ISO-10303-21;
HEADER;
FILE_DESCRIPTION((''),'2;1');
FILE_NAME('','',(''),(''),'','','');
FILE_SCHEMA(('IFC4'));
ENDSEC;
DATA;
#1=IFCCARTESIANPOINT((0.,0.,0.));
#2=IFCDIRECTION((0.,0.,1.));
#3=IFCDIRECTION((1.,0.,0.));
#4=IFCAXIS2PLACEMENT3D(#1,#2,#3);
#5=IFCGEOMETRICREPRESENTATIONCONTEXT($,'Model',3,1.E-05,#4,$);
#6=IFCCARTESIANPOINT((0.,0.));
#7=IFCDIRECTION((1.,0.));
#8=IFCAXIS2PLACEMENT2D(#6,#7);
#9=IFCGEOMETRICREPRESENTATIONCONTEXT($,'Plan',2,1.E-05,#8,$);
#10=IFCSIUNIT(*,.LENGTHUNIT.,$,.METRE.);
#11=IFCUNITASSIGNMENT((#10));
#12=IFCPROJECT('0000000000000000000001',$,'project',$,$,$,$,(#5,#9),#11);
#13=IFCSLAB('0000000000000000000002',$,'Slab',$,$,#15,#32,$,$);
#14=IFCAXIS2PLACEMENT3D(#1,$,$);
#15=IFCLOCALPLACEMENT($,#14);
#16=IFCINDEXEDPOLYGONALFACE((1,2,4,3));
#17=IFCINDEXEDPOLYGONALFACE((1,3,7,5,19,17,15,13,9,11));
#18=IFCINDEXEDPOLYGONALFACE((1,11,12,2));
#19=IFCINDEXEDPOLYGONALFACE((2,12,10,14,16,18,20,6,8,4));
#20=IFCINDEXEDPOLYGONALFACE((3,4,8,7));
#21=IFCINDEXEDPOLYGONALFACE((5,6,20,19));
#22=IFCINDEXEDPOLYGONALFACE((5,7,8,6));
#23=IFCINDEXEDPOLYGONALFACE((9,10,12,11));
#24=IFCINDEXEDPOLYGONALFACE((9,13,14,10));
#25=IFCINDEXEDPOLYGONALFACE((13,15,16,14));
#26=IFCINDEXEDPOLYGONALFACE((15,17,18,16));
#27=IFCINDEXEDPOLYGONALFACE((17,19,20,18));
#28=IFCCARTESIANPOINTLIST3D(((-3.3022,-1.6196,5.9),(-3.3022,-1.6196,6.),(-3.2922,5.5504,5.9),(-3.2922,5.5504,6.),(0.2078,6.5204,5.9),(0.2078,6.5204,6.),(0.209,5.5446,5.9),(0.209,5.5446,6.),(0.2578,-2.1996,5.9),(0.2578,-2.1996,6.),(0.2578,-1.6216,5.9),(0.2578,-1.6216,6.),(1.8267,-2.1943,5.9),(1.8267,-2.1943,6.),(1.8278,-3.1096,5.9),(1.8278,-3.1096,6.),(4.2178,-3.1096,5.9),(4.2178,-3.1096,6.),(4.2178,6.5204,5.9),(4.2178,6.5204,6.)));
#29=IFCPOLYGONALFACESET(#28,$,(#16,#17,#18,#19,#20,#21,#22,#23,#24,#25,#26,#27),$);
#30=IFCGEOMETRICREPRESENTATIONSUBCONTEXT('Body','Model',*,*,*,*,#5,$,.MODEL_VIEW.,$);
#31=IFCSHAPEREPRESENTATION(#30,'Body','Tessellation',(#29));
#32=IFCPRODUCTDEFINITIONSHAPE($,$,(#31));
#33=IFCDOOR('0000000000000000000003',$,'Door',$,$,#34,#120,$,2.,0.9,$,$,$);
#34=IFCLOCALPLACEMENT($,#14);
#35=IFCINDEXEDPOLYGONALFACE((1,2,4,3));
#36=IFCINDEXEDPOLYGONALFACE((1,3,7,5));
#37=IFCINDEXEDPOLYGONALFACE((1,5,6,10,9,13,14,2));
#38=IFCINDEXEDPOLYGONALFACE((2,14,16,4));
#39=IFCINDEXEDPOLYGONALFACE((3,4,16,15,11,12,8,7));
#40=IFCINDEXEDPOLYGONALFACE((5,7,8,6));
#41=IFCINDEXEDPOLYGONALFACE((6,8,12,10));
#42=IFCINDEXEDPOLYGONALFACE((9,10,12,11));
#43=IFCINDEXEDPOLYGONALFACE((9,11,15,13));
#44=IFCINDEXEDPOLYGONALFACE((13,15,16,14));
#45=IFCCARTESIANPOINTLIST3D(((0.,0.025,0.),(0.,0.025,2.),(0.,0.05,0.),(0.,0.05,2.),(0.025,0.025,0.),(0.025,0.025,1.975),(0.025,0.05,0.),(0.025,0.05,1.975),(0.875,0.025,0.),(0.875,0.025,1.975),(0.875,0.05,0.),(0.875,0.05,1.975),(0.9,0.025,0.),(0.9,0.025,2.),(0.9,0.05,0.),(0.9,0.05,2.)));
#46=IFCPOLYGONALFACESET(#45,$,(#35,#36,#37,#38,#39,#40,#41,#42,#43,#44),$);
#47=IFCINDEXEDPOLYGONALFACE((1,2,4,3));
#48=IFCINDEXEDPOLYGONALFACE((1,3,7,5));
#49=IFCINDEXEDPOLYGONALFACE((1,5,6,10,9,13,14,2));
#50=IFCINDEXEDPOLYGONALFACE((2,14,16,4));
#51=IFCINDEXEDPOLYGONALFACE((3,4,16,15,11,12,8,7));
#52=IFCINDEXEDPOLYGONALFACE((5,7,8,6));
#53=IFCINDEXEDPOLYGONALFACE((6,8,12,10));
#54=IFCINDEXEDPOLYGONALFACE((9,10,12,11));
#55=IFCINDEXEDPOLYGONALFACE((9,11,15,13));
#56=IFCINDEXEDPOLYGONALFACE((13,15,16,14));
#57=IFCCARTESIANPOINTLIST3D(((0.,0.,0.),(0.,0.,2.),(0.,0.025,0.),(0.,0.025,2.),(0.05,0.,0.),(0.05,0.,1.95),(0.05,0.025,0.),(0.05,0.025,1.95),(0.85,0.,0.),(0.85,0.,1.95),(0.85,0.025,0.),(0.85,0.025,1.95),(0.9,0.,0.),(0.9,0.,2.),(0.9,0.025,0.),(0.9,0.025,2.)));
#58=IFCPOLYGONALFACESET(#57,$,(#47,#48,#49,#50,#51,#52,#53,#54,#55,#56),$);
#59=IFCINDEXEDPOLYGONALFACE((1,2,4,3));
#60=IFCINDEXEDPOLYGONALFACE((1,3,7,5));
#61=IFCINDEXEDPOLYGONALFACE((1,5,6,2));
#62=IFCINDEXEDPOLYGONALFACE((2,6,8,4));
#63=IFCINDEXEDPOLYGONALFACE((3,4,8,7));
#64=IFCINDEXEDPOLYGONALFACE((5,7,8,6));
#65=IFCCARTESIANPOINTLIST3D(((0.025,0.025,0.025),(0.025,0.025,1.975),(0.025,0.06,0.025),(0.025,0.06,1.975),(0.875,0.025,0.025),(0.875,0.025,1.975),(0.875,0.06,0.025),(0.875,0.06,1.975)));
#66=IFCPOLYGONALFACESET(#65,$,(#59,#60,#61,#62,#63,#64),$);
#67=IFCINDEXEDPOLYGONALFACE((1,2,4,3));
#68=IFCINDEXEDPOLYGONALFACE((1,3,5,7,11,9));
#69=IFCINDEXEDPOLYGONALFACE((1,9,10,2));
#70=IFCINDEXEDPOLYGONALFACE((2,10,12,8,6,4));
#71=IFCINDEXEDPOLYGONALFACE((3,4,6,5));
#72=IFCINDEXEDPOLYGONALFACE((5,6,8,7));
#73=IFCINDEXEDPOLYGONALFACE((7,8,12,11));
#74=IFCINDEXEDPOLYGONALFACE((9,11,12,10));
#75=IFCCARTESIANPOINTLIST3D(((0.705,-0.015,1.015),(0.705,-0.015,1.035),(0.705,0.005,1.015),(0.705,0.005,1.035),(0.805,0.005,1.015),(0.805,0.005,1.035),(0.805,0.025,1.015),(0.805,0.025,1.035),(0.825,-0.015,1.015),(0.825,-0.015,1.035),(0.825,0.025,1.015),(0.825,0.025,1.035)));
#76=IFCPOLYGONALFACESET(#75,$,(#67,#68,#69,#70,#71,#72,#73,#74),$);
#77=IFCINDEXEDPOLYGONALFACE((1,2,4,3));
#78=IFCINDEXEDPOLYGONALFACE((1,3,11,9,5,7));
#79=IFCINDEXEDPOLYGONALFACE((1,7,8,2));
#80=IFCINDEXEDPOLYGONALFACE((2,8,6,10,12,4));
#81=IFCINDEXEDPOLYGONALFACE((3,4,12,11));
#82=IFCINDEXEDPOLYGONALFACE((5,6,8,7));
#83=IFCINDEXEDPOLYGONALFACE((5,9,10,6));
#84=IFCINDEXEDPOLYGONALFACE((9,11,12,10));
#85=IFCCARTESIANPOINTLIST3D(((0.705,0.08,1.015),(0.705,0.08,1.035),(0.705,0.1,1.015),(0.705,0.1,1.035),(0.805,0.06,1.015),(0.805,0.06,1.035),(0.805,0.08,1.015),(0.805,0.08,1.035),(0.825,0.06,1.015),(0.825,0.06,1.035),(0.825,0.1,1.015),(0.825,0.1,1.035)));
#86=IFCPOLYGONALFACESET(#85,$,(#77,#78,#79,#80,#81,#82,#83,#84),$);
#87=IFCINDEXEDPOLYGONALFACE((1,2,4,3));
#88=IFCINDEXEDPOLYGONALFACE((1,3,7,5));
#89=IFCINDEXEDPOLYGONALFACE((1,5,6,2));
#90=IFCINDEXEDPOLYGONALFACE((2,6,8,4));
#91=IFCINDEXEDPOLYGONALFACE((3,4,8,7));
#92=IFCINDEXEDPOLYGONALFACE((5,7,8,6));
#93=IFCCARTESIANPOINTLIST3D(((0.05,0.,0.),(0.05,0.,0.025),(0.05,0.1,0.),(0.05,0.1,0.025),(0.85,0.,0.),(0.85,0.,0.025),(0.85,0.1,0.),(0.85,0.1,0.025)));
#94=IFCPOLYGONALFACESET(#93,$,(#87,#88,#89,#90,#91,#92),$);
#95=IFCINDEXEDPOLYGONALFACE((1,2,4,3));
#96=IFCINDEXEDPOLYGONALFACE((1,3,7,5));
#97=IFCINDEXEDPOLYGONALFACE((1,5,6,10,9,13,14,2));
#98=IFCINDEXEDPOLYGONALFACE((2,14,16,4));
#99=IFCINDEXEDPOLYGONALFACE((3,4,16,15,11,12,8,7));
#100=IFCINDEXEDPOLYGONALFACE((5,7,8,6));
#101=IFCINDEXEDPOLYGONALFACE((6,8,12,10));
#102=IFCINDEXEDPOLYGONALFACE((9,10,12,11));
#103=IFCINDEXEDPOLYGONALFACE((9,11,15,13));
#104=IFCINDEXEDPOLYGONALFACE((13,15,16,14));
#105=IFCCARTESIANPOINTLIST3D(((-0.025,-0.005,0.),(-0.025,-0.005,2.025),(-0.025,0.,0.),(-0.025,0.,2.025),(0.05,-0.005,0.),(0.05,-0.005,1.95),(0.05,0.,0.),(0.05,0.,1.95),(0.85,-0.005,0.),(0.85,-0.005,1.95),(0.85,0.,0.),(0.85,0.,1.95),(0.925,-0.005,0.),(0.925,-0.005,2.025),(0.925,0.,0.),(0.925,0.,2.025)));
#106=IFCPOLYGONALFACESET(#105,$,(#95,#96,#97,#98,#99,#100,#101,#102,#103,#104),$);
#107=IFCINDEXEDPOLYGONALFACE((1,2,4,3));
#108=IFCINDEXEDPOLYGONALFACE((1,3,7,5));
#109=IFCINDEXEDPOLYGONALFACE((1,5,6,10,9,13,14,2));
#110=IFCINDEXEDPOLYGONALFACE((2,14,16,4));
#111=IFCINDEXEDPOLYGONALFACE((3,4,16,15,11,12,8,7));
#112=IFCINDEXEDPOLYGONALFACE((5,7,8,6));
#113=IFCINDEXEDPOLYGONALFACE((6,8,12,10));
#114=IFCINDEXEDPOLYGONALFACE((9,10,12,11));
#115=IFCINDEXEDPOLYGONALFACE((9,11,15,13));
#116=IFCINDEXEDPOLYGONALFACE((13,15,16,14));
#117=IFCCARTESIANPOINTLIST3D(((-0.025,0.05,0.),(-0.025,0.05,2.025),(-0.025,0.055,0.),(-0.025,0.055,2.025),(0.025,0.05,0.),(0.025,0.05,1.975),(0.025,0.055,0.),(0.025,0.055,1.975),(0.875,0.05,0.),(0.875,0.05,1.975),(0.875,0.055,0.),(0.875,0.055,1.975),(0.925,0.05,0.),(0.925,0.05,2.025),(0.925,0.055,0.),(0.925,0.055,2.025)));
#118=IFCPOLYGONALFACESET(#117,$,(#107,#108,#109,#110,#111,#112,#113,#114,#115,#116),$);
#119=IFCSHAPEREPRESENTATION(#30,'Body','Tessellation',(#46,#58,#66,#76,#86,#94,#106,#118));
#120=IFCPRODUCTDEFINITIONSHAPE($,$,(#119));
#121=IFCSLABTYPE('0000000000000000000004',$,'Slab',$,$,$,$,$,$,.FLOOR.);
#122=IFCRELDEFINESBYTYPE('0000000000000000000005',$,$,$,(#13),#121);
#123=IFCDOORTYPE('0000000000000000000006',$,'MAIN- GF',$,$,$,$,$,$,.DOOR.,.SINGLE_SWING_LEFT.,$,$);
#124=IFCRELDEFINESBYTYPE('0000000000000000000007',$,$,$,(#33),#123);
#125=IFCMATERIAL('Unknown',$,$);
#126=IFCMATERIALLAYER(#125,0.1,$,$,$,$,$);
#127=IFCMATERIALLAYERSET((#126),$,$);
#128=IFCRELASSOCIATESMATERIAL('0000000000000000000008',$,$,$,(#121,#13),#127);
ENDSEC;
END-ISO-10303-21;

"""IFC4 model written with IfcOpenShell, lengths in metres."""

from ifc_helpers import new_model, entity, si_unit, frame, origin_with_axes, origin_2d_with_axis, place, context, subcontext, project, line, indexed_curve, outline, extrude, shape, source, transform, mapped, material, layer, layer_set, layer_usage, type_object, type_shapes, element, save


model = new_model("IFC4")

# Units and contexts
model_context = context("Model", 3, precision=1e-05, world=origin_with_axes())
plan_context = context("Plan", 2, precision=1e-05, world=origin_2d_with_axis())
body_context_1 = subcontext(model_context, "Body", "Model", "MODEL_VIEW")
body_context_2 = subcontext(plan_context, "Body", "Plan", "PLAN_VIEW")
ifc_project = project(units=[si_unit("LENGTHUNIT", "METRE")], contexts=[model_context, plan_context])

# Slab
ifc_material = material(Name="Unknown")
ifc_layer = layer(ifc_material, 0.1)
ifc_layer_set = layer_set([ifc_layer])
ifc_layer_usage = layer_usage(ifc_layer_set, "AXIS3", "POSITIVE", -0.1)
slab_type = type_object("IfcSlabType", Name="Slab", PredefinedType="FLOOR", material=ifc_layer_set)
placement_1 = place(None, origin_with_axes())
placement_2 = place(placement_1, origin_with_axes())
placement_3 = place(placement_2, frame((0.0, 0.0, 6.0), z_axis=(0.0, 0.0, 1.0), x_axis=(1.0, 0.0, 0.0)))
slab_placement = place(placement_3, frame((-3.2922, 5.5504, 0.0), z_axis=(0.0, 0.0, 1.0), x_axis=(1.0, 0.0, 0.0)))
element("IfcSlab", 1, at=slab_placement, type_object=slab_type, material=ifc_layer_usage, Name="Slab", context=body_context_1, shape_type="SweptSolid", body=[
    extrude(outline(indexed_curve([(0.0, 0.0), (3.5012, -0.0058), (3.5, 0.97), (7.51, 0.97), (7.51, -8.66), (5.12, -8.66), (5.1189, -7.7447), (3.55, -7.75), (3.55, -7.172), (-0.01, -7.17), (0.0, 0.0)])), frame((0.0, 0.0, -0.1), z_axis=(0.0, 0.0, 1.0), x_axis=(1.0, 0.0, 0.0)), (0.0, 0.0, 1.0), 0.1),
])

# Door
door_type = type_object("IfcDoorType", Name="MAIN- GF", OperationType="SINGLE_SWING_LEFT", PredefinedType="DOOR")
shared_shape_1 = source(origin_with_axes(), body_context_1, "Body", "SweptSolid", [
    extrude(outline(indexed_curve([(0.0, 0.0), (0.0, 2.0), (0.9, 2.0), (0.9, 0.0), (0.875, 0.0), (0.875, 1.975), (0.025, 1.975), (0.025, 0.0)], segments=[line(1, 2, 3, 4, 5, 6, 7, 8, 1)])), frame((0.0, 0.025, 0.0), z_axis=(0.0, -1.0, 0.0), x_axis=(1.0, 0.0, 0.0)), (0.0, 0.0, -1.0), 0.025),
    extrude(outline(indexed_curve([(0.0, 0.0), (0.0, 2.0), (0.9, 2.0), (0.9, 0.0), (0.85, 0.0), (0.85, 1.95), (0.05, 1.95), (0.05, 0.0)], segments=[line(1, 2, 3, 4, 5, 6, 7, 8, 1)])), frame((0.0, 0.0, 0.0), z_axis=(0.0, -1.0, 0.0), x_axis=(1.0, 0.0, 0.0)), (0.0, 0.0, -1.0), 0.025),
    extrude(outline(indexed_curve([(0.0, 0.0), (0.85, 0.0), (0.85, 0.035), (0.0, 0.035)], segments=[line(1, 2, 3, 4, 1)])), frame((0.025, 0.025, 0.025), z_axis=(0.0, 0.0, 1.0), x_axis=(1.0, 0.0, 0.0)), (0.0, 0.0, 1.0), 1.95),
    extrude(outline(indexed_curve([(0.0, 0.0), (0.0, -0.04), (-0.12, -0.04), (-0.12, -0.02), (-0.02, -0.02), (-0.02, 0.0)], segments=[line(1, 2, 3, 4, 5, 6, 1)])), frame((0.825, 0.025, 1.015), z_axis=(0.0, 0.0, 1.0), x_axis=(1.0, 0.0, 0.0)), (0.0, 0.0, 1.0), 0.02),
    extrude(outline(indexed_curve([(0.0, 0.0), (0.0, 0.04), (-0.12, 0.04), (-0.12, 0.02), (-0.02, 0.02), (-0.02, 0.0)], segments=[line(1, 2, 3, 4, 5, 6, 1)])), frame((0.825, 0.06, 1.015), z_axis=(0.0, 0.0, 1.0), x_axis=(1.0, 0.0, 0.0)), (0.0, 0.0, 1.0), 0.02),
    extrude(outline(indexed_curve([(0.0, 0.0), (0.8, 0.0), (0.8, 0.1), (0.0, 0.1)], segments=[line(1, 2, 3, 4, 1)])), frame((0.05, 0.0, 0.0), z_axis=(0.0, 0.0, 1.0), x_axis=(1.0, 0.0, 0.0)), (0.0, 0.0, 1.0), 0.025),
    extrude(outline(indexed_curve([(0.0, 0.0), (0.0, 2.025), (0.95, 2.025), (0.95, 0.0), (0.875, 0.0), (0.875, 1.95), (0.075, 1.95), (0.075, 0.0)], segments=[line(1, 2, 3, 4, 5, 6, 7, 8, 1)])), frame((-0.025, -0.005, 0.0), z_axis=(0.0, -1.0, 0.0), x_axis=(1.0, 0.0, 0.0)), (0.0, 0.0, -1.0), 0.005),
    extrude(outline(indexed_curve([(0.0, 0.0), (0.0, 2.025), (0.95, 2.025), (0.95, 0.0), (0.9, 0.0), (0.9, 1.975), (0.05, 1.975), (0.05, 0.0)], segments=[line(1, 2, 3, 4, 5, 6, 7, 8, 1)])), frame((-0.025, 0.05, 0.0), z_axis=(0.0, -1.0, 0.0), x_axis=(1.0, 0.0, 0.0)), (0.0, 0.0, -1.0), 0.005),
])
shared_shape_2 = source(origin_with_axes(), body_context_2, "Body", "Curve2D", [
    entity("IfcIndexedPolyCurve", entity("IfcCartesianPointList2D", [[0.0, 0.0], [0.0, 0.05], [0.025, 0.05], [0.025, 0.025], [0.05, 0.025], [0.05, 0.0]]), [entity("IfcLineIndex", [1, 2, 3, 4, 5, 6, 1])]),
    entity("IfcIndexedPolyCurve", entity("IfcCartesianPointList2D", [[0.9, 0.0], [0.9, 0.05], [0.875, 0.05], [0.875, 0.025], [0.85, 0.025], [0.85, 0.0]]), [entity("IfcLineIndex", [1, 2, 3, 4, 5, 6, 1])]),
    entity("IfcTrimmedCurve", entity("IfcEllipse", entity("IfcAxis2Placement2D", entity("IfcCartesianPoint", [0.06, 0.05]), entity("IfcDirection", [1.0, 0.0])), 0.815, 0.85), [entity("IfcCartesianPoint", [0.875, 0.05])], [entity("IfcCartesianPoint", [0.06, 0.9])], True, "CARTESIAN"),
    entity("IfcIndexedPolyCurve", entity("IfcCartesianPointList2D", [[0.025, 0.05], [0.06, 0.05], [0.06, 0.9], [0.025, 0.9]]), [entity("IfcLineIndex", [1, 2, 3, 4, 1])]),
])
type_shapes(door_type, [shared_shape_1, shared_shape_2])
element("IfcDoor", 2, type_object=door_type, Name="Door", OverallHeight=2.0, OverallWidth=0.9, shapes=[
    shape(body_context_1, "Body", "MappedRepresentation", [mapped(shared_shape_1, transform((0.0, 0.0, 0.0), x_axis=(1.0, 0.0, 0.0), y_axis=(0.0, 1.0, 0.0), z_axis=(0.0, 0.0, 1.0), scale=1.0))]),
    shape(body_context_2, "Body", "MappedRepresentation", [mapped(shared_shape_2, transform((0.0, 0.0, 0.0), x_axis=(1.0, 0.0, 0.0), y_axis=(0.0, 1.0, 0.0), z_axis=(0.0, 0.0, 1.0), scale=1.0))]),
])

save(model, "model.ifc")
